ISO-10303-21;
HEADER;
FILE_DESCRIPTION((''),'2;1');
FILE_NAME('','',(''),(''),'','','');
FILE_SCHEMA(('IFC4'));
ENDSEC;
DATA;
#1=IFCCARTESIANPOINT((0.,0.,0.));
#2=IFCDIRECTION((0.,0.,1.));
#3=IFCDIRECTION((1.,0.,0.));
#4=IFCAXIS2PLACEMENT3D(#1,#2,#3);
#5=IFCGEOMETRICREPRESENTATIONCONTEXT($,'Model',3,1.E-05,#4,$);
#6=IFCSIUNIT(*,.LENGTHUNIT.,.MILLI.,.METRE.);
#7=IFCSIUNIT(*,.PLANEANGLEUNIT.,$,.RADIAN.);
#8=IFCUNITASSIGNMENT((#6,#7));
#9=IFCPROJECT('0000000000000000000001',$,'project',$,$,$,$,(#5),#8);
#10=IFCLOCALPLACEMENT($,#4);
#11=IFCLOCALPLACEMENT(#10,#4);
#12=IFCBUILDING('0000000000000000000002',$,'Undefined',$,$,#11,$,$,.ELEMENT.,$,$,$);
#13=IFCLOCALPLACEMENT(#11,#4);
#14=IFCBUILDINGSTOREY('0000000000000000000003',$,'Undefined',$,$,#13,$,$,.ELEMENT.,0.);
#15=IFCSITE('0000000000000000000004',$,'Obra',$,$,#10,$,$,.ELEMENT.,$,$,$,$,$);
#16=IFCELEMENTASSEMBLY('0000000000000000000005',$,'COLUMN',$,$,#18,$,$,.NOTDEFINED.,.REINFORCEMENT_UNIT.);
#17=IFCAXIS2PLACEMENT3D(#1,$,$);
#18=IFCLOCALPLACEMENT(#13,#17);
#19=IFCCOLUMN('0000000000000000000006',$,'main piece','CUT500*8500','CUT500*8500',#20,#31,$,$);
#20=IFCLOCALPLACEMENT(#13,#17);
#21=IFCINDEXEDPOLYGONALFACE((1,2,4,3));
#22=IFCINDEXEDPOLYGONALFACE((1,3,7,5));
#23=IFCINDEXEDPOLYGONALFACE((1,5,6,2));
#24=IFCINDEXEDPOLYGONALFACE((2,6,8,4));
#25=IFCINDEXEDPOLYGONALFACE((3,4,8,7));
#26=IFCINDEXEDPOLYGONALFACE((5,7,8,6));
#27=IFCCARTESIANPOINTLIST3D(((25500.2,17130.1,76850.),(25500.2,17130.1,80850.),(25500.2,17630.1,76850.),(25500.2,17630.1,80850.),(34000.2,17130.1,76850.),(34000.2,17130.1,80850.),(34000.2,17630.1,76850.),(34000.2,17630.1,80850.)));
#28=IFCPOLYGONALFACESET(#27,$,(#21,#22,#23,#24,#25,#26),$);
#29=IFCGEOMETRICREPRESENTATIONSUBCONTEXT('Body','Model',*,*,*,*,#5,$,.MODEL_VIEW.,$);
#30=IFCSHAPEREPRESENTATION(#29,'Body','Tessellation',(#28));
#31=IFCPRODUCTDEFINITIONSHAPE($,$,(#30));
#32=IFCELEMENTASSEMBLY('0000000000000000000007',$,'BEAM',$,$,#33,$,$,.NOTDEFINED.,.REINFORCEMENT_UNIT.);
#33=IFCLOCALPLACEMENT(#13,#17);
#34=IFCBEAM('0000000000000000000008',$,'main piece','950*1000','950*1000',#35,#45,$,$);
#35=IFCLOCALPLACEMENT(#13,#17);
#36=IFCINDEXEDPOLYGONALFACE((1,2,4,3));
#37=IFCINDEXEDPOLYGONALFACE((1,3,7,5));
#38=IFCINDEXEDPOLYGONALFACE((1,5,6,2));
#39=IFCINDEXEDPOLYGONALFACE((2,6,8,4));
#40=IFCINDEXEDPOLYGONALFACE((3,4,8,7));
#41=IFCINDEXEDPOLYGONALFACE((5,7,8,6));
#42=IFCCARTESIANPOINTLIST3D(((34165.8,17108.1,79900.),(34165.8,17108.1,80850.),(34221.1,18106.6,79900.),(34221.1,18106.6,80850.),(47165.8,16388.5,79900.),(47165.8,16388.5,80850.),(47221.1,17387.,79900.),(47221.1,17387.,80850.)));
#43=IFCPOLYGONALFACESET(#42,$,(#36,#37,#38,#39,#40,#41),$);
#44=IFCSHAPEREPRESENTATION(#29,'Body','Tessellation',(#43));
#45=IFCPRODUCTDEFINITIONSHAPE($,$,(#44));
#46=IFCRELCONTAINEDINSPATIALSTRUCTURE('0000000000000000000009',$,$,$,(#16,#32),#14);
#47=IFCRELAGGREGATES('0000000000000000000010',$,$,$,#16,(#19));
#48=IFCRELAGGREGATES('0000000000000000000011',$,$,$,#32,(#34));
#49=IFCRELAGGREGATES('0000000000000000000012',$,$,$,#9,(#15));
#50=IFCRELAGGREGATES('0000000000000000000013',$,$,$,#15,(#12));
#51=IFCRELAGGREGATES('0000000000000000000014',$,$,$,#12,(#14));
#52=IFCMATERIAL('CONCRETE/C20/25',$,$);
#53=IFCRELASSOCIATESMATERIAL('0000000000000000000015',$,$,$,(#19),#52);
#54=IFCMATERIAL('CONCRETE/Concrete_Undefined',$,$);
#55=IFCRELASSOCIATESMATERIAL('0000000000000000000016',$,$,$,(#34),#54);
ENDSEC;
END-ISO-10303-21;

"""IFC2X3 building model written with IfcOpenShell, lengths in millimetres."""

from ifc_helpers import new_model, si_unit, frame, origin_with_axes, origin_2d_with_axis, place, context, subcontext, project, spatial, rectangle, extrude, material, element, aggregate, save


model = new_model("IFC2X3")

# Units and contexts
model_context = context("Model", 3, precision=1e-05, world=origin_with_axes())
body_context = subcontext(model_context, "Body", "Model", "MODEL_VIEW")
ifc_project = project(units=[si_unit("LENGTHUNIT", "METRE", prefix="MILLI"), si_unit("PLANEANGLEUNIT", "RADIAN")], contexts=[model_context])

# Site, building, storey
site_placement = place(None, origin_with_axes())
site = spatial("IfcSite", under=ifc_project, at=site_placement, Name="Obra", CompositionType="ELEMENT")
building_placement = place(site_placement, origin_with_axes())
building = spatial("IfcBuilding", under=site, at=building_placement, Name="Undefined", CompositionType="ELEMENT")
storey_placement = place(building_placement, origin_with_axes())
storey = spatial("IfcBuildingStorey", under=building, at=storey_placement, Name="Undefined", CompositionType="ELEMENT", Elevation=0.0)

# Element assembly, column
assembly_1_placement = place(storey_placement, origin_with_axes())
assembly_1 = element("IfcElementAssembly", 1, at=assembly_1_placement, inside=storey, Name="COLUMN", AssemblyPlace="NOTDEFINED", PredefinedType="REINFORCEMENT_UNIT")
ifc_material_1 = material(Name="CONCRETE/C20/25")
column_placement = place(assembly_1_placement, frame((29750.2, 17380.1, 76850.0), z_axis=(0.0, 0.0, 1.0), x_axis=(-1.0, 0.0, 0.0)))
column = element("IfcColumn", 2, at=column_placement, material=ifc_material_1, Name="main piece", Description="CUT500*8500", ObjectType="CUT500*8500", context=body_context, shape_type="SweptSolid", body=[
    extrude(rectangle(XDim=500.0, YDim=8500.0, at=origin_2d_with_axis()), frame((0.0, 0.0, 4000.0), z_axis=(0.0, 0.0, -1.0), x_axis=(0.0, 1.0, 0.0)), (0.0, 0.0, 1.0), 4000.0),
])
aggregate(assembly_1, [column])

# Element assembly, beam
assembly_2_placement = place(storey_placement, origin_with_axes())
assembly_2 = element("IfcElementAssembly", 3, at=assembly_2_placement, inside=storey, Name="BEAM", AssemblyPlace="NOTDEFINED", PredefinedType="REINFORCEMENT_UNIT")
ifc_material_2 = material(Name="CONCRETE/Concrete_Undefined")
beam_1_placement = place(assembly_2_placement, frame((34193.5, 17607.3, 80375.0), z_axis=(0.0, 0.0, 1.0), x_axis=(0.998472, -0.055268, 0.0)))
beam_1 = element("IfcBeam", 4, at=beam_1_placement, material=ifc_material_2, Name="main piece", Description="950*1000", ObjectType="950*1000", context=body_context, shape_type="SweptSolid", body=[
    extrude(rectangle(XDim=1000.0, YDim=950.0, at=origin_2d_with_axis()), frame((13019.9, 0.0, 0.0), z_axis=(-1.0, 0.0, 0.0), x_axis=(0.0, -1.0, 0.0)), (0.0, 0.0, 1.0), 13019.9),
])
aggregate(assembly_2, [beam_1])

save(model, "model.ifc")
